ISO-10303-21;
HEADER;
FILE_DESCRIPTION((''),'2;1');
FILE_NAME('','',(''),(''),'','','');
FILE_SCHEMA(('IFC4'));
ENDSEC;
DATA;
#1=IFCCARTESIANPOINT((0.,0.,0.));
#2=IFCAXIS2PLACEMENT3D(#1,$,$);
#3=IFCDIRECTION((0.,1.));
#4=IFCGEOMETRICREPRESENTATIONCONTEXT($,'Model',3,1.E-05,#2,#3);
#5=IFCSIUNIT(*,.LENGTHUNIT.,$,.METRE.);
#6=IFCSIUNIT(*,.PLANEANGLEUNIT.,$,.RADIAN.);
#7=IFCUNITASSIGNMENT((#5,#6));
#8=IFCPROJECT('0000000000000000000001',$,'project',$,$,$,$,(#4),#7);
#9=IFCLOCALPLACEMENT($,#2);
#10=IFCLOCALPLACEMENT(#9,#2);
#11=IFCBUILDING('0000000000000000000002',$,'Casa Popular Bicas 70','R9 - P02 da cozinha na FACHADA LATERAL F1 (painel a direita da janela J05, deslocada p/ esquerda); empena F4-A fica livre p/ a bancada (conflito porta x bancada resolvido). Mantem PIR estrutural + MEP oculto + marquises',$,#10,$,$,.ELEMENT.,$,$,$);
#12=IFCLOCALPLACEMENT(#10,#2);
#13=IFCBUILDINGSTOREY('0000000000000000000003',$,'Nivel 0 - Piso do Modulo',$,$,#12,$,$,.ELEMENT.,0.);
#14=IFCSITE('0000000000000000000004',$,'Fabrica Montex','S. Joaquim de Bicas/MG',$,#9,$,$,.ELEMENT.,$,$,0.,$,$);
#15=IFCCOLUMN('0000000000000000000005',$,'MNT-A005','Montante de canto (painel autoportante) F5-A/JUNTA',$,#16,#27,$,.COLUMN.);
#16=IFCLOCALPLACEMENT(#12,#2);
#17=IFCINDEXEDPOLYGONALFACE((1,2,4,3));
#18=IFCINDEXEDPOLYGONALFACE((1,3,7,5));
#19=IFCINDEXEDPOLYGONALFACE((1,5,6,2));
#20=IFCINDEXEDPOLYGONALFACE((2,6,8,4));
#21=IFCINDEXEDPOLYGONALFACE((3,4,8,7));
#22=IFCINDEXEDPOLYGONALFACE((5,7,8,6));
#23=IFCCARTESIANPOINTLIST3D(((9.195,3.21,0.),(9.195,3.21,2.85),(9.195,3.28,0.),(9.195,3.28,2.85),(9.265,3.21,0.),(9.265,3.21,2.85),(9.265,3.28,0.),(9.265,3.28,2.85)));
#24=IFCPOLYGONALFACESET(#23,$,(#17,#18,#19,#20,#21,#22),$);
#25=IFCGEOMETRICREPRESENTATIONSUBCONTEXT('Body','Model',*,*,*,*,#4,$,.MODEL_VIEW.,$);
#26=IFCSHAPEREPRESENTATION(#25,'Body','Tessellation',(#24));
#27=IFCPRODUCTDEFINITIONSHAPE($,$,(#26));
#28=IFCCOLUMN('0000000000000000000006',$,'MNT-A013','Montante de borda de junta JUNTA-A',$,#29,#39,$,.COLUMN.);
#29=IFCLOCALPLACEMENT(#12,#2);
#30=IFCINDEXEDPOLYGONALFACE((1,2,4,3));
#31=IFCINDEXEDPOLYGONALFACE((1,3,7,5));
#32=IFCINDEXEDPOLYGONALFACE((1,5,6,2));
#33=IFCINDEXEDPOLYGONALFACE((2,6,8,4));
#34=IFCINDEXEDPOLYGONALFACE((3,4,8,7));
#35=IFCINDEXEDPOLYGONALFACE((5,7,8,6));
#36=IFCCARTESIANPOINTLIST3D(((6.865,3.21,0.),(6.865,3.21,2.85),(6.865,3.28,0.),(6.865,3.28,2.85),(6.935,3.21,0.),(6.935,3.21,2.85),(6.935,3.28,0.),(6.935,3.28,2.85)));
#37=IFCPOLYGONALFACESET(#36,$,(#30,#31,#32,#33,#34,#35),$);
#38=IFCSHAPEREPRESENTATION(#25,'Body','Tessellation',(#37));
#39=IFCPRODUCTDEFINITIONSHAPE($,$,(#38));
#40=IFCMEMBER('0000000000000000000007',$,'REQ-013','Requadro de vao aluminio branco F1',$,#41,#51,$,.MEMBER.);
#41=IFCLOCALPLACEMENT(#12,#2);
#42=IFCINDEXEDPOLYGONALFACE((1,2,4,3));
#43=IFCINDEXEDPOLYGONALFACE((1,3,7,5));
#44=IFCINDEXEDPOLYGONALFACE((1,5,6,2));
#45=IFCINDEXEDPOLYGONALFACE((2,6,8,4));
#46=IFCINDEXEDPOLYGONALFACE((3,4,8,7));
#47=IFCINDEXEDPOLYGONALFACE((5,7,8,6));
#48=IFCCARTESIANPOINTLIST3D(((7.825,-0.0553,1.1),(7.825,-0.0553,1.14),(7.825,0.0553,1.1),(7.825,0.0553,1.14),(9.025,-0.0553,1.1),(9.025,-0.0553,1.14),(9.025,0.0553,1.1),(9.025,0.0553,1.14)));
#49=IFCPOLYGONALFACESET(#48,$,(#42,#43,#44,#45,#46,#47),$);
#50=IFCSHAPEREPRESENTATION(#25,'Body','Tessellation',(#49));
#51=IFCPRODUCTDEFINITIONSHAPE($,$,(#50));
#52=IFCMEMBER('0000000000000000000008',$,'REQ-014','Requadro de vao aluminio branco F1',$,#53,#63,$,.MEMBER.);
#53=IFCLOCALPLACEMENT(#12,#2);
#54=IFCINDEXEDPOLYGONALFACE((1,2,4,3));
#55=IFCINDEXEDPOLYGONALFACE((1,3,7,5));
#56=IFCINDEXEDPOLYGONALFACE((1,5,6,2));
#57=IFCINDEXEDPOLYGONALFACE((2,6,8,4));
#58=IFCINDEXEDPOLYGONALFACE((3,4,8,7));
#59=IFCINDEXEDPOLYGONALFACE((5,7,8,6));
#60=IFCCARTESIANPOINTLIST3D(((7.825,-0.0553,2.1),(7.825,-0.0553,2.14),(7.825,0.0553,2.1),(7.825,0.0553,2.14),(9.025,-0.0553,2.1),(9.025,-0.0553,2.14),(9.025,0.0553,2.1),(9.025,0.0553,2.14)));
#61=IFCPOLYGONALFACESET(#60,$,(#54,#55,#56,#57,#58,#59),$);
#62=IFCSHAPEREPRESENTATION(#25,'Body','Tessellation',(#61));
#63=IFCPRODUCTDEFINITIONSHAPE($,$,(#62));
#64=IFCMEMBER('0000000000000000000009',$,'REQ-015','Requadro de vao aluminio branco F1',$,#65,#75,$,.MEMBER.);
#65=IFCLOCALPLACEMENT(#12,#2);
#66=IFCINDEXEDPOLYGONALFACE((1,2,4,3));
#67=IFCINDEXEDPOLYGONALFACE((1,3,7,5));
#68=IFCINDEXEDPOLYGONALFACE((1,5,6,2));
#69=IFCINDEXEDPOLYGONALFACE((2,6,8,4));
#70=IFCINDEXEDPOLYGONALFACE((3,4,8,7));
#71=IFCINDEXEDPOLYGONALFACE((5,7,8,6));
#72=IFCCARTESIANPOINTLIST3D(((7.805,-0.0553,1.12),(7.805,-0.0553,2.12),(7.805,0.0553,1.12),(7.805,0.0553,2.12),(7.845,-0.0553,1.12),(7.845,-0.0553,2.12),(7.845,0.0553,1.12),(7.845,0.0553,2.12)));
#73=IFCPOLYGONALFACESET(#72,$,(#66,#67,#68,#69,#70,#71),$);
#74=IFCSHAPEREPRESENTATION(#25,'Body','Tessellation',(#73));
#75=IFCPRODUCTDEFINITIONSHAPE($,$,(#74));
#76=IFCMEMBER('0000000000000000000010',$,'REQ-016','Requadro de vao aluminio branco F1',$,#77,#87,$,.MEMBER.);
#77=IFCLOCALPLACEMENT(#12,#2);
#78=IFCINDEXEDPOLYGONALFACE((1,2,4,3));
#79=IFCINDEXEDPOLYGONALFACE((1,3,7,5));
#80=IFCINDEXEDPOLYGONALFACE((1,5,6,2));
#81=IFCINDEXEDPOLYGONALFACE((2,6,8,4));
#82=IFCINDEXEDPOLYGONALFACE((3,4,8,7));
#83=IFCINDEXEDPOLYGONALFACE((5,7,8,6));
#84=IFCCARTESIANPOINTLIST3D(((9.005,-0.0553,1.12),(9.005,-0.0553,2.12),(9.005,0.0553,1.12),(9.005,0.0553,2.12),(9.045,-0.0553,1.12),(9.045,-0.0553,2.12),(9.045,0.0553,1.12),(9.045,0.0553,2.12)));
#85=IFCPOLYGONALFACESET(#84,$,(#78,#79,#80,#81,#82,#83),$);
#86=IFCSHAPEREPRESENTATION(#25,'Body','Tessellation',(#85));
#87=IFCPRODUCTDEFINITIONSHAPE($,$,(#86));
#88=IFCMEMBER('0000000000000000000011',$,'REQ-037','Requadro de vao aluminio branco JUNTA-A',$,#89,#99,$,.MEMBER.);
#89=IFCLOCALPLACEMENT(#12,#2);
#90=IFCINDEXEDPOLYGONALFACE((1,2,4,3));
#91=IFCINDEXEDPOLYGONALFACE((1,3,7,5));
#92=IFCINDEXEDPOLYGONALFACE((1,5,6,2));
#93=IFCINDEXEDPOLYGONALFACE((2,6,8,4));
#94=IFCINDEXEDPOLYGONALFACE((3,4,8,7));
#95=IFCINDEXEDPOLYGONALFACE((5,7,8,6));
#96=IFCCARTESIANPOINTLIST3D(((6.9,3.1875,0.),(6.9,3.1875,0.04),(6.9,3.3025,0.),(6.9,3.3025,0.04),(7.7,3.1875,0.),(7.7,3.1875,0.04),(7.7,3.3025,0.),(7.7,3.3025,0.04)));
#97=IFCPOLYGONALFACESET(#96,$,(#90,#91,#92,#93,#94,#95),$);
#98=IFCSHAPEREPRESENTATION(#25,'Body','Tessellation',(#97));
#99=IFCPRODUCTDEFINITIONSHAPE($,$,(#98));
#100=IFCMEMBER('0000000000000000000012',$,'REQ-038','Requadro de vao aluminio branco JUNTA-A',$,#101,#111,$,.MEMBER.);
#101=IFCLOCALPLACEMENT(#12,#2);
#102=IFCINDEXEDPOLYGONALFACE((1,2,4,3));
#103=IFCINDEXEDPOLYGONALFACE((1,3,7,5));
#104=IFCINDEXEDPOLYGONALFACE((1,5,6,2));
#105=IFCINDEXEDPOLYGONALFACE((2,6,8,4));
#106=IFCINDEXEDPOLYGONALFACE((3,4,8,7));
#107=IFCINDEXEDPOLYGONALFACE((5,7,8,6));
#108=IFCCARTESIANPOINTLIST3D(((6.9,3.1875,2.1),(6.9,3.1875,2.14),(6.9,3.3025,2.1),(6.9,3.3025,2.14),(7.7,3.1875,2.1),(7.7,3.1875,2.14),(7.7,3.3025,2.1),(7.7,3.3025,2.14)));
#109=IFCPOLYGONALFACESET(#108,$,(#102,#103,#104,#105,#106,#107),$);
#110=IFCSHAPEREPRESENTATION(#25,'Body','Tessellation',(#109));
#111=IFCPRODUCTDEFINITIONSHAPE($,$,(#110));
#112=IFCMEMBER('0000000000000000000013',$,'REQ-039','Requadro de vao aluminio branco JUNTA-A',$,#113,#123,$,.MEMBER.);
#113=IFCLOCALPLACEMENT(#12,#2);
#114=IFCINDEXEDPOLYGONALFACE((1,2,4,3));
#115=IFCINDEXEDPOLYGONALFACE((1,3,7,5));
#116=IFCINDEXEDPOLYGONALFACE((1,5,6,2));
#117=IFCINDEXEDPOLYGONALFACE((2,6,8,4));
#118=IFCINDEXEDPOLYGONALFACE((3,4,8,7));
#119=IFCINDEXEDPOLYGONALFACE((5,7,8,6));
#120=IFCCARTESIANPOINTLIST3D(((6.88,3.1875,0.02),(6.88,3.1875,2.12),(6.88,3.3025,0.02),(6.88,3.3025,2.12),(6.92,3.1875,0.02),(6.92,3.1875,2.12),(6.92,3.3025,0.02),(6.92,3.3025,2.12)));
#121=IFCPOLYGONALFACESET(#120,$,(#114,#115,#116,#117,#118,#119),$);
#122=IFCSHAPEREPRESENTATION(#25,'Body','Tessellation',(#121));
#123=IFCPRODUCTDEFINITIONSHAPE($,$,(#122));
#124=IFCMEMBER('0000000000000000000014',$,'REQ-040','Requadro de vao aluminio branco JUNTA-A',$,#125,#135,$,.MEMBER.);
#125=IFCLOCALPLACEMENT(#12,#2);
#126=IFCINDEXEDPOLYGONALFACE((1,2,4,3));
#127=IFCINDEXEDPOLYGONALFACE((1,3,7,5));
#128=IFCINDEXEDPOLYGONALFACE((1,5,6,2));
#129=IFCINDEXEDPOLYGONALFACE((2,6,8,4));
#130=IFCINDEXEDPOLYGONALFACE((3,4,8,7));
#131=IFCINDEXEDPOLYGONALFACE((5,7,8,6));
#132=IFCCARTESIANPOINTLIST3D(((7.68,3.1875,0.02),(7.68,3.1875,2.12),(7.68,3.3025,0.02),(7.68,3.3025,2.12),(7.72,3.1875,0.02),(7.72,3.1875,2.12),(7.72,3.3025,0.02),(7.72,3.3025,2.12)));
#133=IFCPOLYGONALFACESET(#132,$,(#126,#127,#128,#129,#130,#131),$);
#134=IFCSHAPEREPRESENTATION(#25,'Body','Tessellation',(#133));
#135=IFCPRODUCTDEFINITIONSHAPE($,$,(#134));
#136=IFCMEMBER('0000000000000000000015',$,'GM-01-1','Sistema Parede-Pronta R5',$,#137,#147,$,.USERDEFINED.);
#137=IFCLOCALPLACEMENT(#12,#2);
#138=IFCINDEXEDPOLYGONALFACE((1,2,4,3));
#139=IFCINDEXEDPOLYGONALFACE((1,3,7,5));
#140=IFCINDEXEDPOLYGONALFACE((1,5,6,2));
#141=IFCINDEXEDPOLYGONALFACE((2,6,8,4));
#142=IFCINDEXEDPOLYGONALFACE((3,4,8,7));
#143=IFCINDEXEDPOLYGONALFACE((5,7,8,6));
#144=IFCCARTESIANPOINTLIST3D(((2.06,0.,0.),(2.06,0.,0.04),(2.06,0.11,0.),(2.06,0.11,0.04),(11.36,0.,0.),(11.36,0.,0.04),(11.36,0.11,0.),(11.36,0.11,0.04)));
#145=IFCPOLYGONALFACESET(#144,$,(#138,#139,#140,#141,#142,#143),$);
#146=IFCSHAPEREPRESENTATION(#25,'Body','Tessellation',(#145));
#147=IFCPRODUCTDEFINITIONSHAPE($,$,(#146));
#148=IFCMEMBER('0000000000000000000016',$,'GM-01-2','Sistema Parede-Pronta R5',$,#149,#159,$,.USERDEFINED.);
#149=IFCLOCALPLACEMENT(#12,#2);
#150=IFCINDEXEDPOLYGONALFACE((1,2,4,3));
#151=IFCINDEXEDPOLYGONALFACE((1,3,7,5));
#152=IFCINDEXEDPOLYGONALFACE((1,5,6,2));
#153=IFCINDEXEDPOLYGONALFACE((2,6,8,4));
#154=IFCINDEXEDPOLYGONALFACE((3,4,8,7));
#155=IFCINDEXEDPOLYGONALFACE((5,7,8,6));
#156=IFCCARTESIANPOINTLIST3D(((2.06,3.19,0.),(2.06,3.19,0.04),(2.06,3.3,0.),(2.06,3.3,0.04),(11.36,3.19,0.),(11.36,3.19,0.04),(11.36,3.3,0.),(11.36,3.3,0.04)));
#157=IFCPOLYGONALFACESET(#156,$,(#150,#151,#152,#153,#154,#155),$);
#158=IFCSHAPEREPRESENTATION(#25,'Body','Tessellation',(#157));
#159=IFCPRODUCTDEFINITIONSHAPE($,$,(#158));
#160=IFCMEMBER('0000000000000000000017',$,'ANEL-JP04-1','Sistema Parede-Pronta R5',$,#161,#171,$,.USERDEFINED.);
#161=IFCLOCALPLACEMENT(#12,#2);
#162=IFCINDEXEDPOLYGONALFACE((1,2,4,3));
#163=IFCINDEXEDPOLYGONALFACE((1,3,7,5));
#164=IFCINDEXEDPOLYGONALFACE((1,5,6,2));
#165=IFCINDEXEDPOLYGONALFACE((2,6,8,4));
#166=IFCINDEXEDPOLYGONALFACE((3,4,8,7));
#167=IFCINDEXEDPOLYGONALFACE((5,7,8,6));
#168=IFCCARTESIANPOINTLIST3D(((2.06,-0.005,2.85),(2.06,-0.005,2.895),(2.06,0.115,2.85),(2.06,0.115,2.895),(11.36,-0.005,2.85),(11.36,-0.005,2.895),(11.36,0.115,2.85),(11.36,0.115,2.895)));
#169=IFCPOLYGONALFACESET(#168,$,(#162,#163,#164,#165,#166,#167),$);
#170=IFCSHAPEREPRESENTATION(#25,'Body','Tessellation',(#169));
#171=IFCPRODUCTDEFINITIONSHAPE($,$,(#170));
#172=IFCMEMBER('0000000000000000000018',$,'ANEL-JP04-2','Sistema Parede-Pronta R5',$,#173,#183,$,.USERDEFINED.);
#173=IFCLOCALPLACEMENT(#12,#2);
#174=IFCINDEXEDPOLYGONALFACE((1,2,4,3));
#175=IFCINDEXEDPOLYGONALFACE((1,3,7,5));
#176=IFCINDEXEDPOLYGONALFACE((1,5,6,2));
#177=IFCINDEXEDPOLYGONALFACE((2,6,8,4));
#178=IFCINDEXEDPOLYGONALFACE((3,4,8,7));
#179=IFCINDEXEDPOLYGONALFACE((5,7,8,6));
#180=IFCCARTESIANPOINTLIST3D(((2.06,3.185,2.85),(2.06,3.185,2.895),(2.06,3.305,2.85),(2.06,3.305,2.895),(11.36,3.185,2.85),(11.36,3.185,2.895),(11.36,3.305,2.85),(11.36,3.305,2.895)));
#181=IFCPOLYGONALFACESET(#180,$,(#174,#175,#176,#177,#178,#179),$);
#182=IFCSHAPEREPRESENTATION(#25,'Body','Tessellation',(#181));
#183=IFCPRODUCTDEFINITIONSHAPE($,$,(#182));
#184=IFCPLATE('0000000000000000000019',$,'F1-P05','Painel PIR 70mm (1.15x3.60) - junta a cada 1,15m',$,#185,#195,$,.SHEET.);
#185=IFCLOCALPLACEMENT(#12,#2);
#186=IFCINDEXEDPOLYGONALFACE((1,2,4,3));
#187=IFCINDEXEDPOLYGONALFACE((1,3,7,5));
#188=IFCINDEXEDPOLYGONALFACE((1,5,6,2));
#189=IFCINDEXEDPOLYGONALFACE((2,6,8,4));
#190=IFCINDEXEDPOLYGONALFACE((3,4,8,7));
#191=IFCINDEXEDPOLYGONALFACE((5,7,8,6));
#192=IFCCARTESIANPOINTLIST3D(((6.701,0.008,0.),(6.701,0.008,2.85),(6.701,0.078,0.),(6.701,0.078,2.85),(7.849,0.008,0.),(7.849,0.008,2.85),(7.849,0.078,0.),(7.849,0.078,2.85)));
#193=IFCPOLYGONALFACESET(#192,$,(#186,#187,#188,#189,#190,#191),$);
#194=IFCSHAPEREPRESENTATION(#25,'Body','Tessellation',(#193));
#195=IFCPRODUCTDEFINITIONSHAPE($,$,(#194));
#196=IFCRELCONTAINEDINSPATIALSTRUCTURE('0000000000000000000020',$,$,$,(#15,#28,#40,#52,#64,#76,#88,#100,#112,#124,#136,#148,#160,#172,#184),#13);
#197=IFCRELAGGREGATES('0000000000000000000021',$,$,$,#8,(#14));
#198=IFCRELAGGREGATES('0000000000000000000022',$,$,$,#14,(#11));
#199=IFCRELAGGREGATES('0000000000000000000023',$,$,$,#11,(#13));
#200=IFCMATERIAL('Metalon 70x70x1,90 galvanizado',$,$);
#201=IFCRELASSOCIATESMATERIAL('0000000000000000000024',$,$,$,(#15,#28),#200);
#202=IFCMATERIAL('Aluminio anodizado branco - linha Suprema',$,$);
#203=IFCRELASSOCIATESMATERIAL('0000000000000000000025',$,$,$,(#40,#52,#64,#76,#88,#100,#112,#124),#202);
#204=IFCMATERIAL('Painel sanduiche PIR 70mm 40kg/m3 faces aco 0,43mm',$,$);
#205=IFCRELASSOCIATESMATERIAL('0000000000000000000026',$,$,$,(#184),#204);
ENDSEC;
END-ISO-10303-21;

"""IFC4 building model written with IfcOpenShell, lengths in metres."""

from ifc_helpers import new_model, si_unit, direction, frame, frame_2d, origin, origin_2d, place, context, subcontext, project, spatial, rectangle, extrude, material, element, save


model = new_model("IFC4")

# Units and contexts
model_context = context("Model", 3, precision=1e-05, world=origin(), true_north=direction((0.0, 1.0)))
body_context = subcontext(model_context, "Body", "Model", "MODEL_VIEW")
ifc_project = project(units=[si_unit("LENGTHUNIT", "METRE"), si_unit("PLANEANGLEUNIT", "RADIAN")], contexts=[model_context])

# Site, building, storey
site_placement = place(None, origin())
site = spatial("IfcSite", under=ifc_project, at=site_placement, Name="Fabrica Montex", Description="S. Joaquim de Bicas/MG", CompositionType="ELEMENT", RefElevation=0.0)
building_placement = place(site_placement, origin())
building = spatial("IfcBuilding", under=site, at=building_placement, Name="Casa Popular Bicas 70", Description="R9 - P02 da cozinha na FACHADA LATERAL F1 (painel a direita da janela J05, deslocada p/ esquerda); empena F4-A fica livre p/ a bancada (conflito porta x bancada resolvido). Mantem PIR estrutural + MEP oculto + marquises", CompositionType="ELEMENT")
storey_placement = place(building_placement, origin())
storey = spatial("IfcBuildingStorey", under=building, at=storey_placement, Name="Nivel 0 - Piso do Modulo", CompositionType="ELEMENT", Elevation=0.0)

# Columns
ifc_material_1 = material(Name="Metalon 70x70x1,90 galvanizado")
for number, where, name, description in (
    (1, (9.23, 3.245, 0.0), "MNT-A005", "Montante de canto (painel autoportante) F5-A/JUNTA"),
    (2, (6.9, 3.245, 0.0), "MNT-A013", "Montante de borda de junta JUNTA-A"),
):
    element("IfcColumn", number, at=place(storey_placement, frame(where)), inside=storey, material=ifc_material_1, Name=name, Description=description, PredefinedType="COLUMN", context=body_context, shape_type="SweptSolid", body=[
        extrude(rectangle(XDim=0.07, YDim=0.07, at=origin_2d()), origin(), (0.0, 0.0, 1.0), 2.85),
    ])

# Members
ifc_material_2 = material(Name="Aluminio anodizado branco - linha Suprema")
for number, where, z_axis, x_axis, name in (
    (3, (7.825, 0.0, 1.12), (1.0, 0.0, 0.0), (0.0, 0.0, 1.0), "REQ-013"),
    (4, (7.825, 0.0, 2.12), (1.0, 0.0, 0.0), (0.0, 0.0, 1.0), "REQ-014"),
):
    element("IfcMember", number, at=place(storey_placement, frame(where, z_axis=z_axis, x_axis=x_axis)), inside=storey, material=ifc_material_2, Name=name, Description="Requadro de vao aluminio branco F1", PredefinedType="MEMBER", context=body_context, shape_type="SweptSolid", body=[
        extrude(rectangle(XDim=0.04, YDim=0.1105, at=origin_2d()), origin(), (0.0, 0.0, 1.0), 1.2),
    ])
for number, where, z_axis, x_axis, name in (
    (5, (7.825, 0.0, 1.12), (0.0, 0.0, 1.0), (1.0, 0.0, 0.0), "REQ-015"),
    (6, (9.025, 0.0, 1.12), (0.0, 0.0, 1.0), (1.0, 0.0, 0.0), "REQ-016"),
):
    element("IfcMember", number, at=place(storey_placement, frame(where, z_axis=z_axis, x_axis=x_axis)), inside=storey, material=ifc_material_2, Name=name, Description="Requadro de vao aluminio branco F1", PredefinedType="MEMBER", context=body_context, shape_type="SweptSolid", body=[
        extrude(rectangle(XDim=0.04, YDim=0.1105, at=origin_2d()), origin(), (0.0, 0.0, 1.0), 1.0),
    ])
for number, where, z_axis, x_axis, name in (
    (7, (6.9, 3.245, 0.02), (1.0, 0.0, 0.0), (0.0, 0.0, 1.0), "REQ-037"),
    (8, (6.9, 3.245, 2.12), (1.0, 0.0, 0.0), (0.0, 0.0, 1.0), "REQ-038"),
):
    element("IfcMember", number, at=place(storey_placement, frame(where, z_axis=z_axis, x_axis=x_axis)), inside=storey, material=ifc_material_2, Name=name, Description="Requadro de vao aluminio branco JUNTA-A", PredefinedType="MEMBER", context=body_context, shape_type="SweptSolid", body=[
        extrude(rectangle(XDim=0.04, YDim=0.115, at=origin_2d()), origin(), (0.0, 0.0, 1.0), 0.8),
    ])
for number, where, z_axis, x_axis, name in (
    (9, (6.9, 3.245, 0.02), (0.0, 0.0, 1.0), (1.0, 0.0, 0.0), "REQ-039"),
    (10, (7.7, 3.245, 0.02), (0.0, 0.0, 1.0), (1.0, 0.0, 0.0), "REQ-040"),
):
    element("IfcMember", number, at=place(storey_placement, frame(where, z_axis=z_axis, x_axis=x_axis)), inside=storey, material=ifc_material_2, Name=name, Description="Requadro de vao aluminio branco JUNTA-A", PredefinedType="MEMBER", context=body_context, shape_type="SweptSolid", body=[
        extrude(rectangle(XDim=0.04, YDim=0.115, at=origin_2d()), origin(), (0.0, 0.0, 1.0), 2.1),
    ])
for number, where, name in (
    (11, (6.71, 0.055, 0.0), "GM-01-1"),
    (12, (6.71, 3.245, 0.0), "GM-01-2"),
):
    element("IfcMember", number, at=place(storey_placement, frame(where)), inside=storey, Name=name, Description="Sistema Parede-Pronta R5", PredefinedType="USERDEFINED", context=body_context, shape_type="SweptSolid", body=[
        extrude(rectangle(XDim=9.3, YDim=0.11, at=origin_2d()), origin(), (0.0, 0.0, 1.0), 0.04),
    ])
for number, where, name in (
    (13, (6.71, 0.055, 2.85), "ANEL-JP04-1"),
    (14, (6.71, 3.245, 2.85), "ANEL-JP04-2"),
):
    element("IfcMember", number, at=place(storey_placement, frame(where)), inside=storey, Name=name, Description="Sistema Parede-Pronta R5", PredefinedType="USERDEFINED", context=body_context, shape_type="SweptSolid", body=[
        extrude(rectangle(XDim=9.3, YDim=0.12, at=origin_2d()), origin(), (0.0, 0.0, 1.0), 0.045),
    ])

# Plate
ifc_material_3 = material(Name="Painel sanduiche PIR 70mm 40kg/m3 faces aco 0,43mm")
plate_1_placement = place(storey_placement, frame((6.701, 0.043, 0.0), x_axis=(1.0, 0.0, 0.0)))
element("IfcPlate", 15, at=plate_1_placement, inside=storey, material=ifc_material_3, Name="F1-P05", Description="Painel PIR 70mm (1.15x3.60) - junta a cada 1,15m", PredefinedType="SHEET", context=body_context, shape_type="SweptSolid", body=[
    extrude(rectangle(XDim=1.148, YDim=0.07, at=frame_2d((0.574, 0.0))), origin(), (0.0, 0.0, 1.0), 2.85),
])

save(model, "model.ifc")
